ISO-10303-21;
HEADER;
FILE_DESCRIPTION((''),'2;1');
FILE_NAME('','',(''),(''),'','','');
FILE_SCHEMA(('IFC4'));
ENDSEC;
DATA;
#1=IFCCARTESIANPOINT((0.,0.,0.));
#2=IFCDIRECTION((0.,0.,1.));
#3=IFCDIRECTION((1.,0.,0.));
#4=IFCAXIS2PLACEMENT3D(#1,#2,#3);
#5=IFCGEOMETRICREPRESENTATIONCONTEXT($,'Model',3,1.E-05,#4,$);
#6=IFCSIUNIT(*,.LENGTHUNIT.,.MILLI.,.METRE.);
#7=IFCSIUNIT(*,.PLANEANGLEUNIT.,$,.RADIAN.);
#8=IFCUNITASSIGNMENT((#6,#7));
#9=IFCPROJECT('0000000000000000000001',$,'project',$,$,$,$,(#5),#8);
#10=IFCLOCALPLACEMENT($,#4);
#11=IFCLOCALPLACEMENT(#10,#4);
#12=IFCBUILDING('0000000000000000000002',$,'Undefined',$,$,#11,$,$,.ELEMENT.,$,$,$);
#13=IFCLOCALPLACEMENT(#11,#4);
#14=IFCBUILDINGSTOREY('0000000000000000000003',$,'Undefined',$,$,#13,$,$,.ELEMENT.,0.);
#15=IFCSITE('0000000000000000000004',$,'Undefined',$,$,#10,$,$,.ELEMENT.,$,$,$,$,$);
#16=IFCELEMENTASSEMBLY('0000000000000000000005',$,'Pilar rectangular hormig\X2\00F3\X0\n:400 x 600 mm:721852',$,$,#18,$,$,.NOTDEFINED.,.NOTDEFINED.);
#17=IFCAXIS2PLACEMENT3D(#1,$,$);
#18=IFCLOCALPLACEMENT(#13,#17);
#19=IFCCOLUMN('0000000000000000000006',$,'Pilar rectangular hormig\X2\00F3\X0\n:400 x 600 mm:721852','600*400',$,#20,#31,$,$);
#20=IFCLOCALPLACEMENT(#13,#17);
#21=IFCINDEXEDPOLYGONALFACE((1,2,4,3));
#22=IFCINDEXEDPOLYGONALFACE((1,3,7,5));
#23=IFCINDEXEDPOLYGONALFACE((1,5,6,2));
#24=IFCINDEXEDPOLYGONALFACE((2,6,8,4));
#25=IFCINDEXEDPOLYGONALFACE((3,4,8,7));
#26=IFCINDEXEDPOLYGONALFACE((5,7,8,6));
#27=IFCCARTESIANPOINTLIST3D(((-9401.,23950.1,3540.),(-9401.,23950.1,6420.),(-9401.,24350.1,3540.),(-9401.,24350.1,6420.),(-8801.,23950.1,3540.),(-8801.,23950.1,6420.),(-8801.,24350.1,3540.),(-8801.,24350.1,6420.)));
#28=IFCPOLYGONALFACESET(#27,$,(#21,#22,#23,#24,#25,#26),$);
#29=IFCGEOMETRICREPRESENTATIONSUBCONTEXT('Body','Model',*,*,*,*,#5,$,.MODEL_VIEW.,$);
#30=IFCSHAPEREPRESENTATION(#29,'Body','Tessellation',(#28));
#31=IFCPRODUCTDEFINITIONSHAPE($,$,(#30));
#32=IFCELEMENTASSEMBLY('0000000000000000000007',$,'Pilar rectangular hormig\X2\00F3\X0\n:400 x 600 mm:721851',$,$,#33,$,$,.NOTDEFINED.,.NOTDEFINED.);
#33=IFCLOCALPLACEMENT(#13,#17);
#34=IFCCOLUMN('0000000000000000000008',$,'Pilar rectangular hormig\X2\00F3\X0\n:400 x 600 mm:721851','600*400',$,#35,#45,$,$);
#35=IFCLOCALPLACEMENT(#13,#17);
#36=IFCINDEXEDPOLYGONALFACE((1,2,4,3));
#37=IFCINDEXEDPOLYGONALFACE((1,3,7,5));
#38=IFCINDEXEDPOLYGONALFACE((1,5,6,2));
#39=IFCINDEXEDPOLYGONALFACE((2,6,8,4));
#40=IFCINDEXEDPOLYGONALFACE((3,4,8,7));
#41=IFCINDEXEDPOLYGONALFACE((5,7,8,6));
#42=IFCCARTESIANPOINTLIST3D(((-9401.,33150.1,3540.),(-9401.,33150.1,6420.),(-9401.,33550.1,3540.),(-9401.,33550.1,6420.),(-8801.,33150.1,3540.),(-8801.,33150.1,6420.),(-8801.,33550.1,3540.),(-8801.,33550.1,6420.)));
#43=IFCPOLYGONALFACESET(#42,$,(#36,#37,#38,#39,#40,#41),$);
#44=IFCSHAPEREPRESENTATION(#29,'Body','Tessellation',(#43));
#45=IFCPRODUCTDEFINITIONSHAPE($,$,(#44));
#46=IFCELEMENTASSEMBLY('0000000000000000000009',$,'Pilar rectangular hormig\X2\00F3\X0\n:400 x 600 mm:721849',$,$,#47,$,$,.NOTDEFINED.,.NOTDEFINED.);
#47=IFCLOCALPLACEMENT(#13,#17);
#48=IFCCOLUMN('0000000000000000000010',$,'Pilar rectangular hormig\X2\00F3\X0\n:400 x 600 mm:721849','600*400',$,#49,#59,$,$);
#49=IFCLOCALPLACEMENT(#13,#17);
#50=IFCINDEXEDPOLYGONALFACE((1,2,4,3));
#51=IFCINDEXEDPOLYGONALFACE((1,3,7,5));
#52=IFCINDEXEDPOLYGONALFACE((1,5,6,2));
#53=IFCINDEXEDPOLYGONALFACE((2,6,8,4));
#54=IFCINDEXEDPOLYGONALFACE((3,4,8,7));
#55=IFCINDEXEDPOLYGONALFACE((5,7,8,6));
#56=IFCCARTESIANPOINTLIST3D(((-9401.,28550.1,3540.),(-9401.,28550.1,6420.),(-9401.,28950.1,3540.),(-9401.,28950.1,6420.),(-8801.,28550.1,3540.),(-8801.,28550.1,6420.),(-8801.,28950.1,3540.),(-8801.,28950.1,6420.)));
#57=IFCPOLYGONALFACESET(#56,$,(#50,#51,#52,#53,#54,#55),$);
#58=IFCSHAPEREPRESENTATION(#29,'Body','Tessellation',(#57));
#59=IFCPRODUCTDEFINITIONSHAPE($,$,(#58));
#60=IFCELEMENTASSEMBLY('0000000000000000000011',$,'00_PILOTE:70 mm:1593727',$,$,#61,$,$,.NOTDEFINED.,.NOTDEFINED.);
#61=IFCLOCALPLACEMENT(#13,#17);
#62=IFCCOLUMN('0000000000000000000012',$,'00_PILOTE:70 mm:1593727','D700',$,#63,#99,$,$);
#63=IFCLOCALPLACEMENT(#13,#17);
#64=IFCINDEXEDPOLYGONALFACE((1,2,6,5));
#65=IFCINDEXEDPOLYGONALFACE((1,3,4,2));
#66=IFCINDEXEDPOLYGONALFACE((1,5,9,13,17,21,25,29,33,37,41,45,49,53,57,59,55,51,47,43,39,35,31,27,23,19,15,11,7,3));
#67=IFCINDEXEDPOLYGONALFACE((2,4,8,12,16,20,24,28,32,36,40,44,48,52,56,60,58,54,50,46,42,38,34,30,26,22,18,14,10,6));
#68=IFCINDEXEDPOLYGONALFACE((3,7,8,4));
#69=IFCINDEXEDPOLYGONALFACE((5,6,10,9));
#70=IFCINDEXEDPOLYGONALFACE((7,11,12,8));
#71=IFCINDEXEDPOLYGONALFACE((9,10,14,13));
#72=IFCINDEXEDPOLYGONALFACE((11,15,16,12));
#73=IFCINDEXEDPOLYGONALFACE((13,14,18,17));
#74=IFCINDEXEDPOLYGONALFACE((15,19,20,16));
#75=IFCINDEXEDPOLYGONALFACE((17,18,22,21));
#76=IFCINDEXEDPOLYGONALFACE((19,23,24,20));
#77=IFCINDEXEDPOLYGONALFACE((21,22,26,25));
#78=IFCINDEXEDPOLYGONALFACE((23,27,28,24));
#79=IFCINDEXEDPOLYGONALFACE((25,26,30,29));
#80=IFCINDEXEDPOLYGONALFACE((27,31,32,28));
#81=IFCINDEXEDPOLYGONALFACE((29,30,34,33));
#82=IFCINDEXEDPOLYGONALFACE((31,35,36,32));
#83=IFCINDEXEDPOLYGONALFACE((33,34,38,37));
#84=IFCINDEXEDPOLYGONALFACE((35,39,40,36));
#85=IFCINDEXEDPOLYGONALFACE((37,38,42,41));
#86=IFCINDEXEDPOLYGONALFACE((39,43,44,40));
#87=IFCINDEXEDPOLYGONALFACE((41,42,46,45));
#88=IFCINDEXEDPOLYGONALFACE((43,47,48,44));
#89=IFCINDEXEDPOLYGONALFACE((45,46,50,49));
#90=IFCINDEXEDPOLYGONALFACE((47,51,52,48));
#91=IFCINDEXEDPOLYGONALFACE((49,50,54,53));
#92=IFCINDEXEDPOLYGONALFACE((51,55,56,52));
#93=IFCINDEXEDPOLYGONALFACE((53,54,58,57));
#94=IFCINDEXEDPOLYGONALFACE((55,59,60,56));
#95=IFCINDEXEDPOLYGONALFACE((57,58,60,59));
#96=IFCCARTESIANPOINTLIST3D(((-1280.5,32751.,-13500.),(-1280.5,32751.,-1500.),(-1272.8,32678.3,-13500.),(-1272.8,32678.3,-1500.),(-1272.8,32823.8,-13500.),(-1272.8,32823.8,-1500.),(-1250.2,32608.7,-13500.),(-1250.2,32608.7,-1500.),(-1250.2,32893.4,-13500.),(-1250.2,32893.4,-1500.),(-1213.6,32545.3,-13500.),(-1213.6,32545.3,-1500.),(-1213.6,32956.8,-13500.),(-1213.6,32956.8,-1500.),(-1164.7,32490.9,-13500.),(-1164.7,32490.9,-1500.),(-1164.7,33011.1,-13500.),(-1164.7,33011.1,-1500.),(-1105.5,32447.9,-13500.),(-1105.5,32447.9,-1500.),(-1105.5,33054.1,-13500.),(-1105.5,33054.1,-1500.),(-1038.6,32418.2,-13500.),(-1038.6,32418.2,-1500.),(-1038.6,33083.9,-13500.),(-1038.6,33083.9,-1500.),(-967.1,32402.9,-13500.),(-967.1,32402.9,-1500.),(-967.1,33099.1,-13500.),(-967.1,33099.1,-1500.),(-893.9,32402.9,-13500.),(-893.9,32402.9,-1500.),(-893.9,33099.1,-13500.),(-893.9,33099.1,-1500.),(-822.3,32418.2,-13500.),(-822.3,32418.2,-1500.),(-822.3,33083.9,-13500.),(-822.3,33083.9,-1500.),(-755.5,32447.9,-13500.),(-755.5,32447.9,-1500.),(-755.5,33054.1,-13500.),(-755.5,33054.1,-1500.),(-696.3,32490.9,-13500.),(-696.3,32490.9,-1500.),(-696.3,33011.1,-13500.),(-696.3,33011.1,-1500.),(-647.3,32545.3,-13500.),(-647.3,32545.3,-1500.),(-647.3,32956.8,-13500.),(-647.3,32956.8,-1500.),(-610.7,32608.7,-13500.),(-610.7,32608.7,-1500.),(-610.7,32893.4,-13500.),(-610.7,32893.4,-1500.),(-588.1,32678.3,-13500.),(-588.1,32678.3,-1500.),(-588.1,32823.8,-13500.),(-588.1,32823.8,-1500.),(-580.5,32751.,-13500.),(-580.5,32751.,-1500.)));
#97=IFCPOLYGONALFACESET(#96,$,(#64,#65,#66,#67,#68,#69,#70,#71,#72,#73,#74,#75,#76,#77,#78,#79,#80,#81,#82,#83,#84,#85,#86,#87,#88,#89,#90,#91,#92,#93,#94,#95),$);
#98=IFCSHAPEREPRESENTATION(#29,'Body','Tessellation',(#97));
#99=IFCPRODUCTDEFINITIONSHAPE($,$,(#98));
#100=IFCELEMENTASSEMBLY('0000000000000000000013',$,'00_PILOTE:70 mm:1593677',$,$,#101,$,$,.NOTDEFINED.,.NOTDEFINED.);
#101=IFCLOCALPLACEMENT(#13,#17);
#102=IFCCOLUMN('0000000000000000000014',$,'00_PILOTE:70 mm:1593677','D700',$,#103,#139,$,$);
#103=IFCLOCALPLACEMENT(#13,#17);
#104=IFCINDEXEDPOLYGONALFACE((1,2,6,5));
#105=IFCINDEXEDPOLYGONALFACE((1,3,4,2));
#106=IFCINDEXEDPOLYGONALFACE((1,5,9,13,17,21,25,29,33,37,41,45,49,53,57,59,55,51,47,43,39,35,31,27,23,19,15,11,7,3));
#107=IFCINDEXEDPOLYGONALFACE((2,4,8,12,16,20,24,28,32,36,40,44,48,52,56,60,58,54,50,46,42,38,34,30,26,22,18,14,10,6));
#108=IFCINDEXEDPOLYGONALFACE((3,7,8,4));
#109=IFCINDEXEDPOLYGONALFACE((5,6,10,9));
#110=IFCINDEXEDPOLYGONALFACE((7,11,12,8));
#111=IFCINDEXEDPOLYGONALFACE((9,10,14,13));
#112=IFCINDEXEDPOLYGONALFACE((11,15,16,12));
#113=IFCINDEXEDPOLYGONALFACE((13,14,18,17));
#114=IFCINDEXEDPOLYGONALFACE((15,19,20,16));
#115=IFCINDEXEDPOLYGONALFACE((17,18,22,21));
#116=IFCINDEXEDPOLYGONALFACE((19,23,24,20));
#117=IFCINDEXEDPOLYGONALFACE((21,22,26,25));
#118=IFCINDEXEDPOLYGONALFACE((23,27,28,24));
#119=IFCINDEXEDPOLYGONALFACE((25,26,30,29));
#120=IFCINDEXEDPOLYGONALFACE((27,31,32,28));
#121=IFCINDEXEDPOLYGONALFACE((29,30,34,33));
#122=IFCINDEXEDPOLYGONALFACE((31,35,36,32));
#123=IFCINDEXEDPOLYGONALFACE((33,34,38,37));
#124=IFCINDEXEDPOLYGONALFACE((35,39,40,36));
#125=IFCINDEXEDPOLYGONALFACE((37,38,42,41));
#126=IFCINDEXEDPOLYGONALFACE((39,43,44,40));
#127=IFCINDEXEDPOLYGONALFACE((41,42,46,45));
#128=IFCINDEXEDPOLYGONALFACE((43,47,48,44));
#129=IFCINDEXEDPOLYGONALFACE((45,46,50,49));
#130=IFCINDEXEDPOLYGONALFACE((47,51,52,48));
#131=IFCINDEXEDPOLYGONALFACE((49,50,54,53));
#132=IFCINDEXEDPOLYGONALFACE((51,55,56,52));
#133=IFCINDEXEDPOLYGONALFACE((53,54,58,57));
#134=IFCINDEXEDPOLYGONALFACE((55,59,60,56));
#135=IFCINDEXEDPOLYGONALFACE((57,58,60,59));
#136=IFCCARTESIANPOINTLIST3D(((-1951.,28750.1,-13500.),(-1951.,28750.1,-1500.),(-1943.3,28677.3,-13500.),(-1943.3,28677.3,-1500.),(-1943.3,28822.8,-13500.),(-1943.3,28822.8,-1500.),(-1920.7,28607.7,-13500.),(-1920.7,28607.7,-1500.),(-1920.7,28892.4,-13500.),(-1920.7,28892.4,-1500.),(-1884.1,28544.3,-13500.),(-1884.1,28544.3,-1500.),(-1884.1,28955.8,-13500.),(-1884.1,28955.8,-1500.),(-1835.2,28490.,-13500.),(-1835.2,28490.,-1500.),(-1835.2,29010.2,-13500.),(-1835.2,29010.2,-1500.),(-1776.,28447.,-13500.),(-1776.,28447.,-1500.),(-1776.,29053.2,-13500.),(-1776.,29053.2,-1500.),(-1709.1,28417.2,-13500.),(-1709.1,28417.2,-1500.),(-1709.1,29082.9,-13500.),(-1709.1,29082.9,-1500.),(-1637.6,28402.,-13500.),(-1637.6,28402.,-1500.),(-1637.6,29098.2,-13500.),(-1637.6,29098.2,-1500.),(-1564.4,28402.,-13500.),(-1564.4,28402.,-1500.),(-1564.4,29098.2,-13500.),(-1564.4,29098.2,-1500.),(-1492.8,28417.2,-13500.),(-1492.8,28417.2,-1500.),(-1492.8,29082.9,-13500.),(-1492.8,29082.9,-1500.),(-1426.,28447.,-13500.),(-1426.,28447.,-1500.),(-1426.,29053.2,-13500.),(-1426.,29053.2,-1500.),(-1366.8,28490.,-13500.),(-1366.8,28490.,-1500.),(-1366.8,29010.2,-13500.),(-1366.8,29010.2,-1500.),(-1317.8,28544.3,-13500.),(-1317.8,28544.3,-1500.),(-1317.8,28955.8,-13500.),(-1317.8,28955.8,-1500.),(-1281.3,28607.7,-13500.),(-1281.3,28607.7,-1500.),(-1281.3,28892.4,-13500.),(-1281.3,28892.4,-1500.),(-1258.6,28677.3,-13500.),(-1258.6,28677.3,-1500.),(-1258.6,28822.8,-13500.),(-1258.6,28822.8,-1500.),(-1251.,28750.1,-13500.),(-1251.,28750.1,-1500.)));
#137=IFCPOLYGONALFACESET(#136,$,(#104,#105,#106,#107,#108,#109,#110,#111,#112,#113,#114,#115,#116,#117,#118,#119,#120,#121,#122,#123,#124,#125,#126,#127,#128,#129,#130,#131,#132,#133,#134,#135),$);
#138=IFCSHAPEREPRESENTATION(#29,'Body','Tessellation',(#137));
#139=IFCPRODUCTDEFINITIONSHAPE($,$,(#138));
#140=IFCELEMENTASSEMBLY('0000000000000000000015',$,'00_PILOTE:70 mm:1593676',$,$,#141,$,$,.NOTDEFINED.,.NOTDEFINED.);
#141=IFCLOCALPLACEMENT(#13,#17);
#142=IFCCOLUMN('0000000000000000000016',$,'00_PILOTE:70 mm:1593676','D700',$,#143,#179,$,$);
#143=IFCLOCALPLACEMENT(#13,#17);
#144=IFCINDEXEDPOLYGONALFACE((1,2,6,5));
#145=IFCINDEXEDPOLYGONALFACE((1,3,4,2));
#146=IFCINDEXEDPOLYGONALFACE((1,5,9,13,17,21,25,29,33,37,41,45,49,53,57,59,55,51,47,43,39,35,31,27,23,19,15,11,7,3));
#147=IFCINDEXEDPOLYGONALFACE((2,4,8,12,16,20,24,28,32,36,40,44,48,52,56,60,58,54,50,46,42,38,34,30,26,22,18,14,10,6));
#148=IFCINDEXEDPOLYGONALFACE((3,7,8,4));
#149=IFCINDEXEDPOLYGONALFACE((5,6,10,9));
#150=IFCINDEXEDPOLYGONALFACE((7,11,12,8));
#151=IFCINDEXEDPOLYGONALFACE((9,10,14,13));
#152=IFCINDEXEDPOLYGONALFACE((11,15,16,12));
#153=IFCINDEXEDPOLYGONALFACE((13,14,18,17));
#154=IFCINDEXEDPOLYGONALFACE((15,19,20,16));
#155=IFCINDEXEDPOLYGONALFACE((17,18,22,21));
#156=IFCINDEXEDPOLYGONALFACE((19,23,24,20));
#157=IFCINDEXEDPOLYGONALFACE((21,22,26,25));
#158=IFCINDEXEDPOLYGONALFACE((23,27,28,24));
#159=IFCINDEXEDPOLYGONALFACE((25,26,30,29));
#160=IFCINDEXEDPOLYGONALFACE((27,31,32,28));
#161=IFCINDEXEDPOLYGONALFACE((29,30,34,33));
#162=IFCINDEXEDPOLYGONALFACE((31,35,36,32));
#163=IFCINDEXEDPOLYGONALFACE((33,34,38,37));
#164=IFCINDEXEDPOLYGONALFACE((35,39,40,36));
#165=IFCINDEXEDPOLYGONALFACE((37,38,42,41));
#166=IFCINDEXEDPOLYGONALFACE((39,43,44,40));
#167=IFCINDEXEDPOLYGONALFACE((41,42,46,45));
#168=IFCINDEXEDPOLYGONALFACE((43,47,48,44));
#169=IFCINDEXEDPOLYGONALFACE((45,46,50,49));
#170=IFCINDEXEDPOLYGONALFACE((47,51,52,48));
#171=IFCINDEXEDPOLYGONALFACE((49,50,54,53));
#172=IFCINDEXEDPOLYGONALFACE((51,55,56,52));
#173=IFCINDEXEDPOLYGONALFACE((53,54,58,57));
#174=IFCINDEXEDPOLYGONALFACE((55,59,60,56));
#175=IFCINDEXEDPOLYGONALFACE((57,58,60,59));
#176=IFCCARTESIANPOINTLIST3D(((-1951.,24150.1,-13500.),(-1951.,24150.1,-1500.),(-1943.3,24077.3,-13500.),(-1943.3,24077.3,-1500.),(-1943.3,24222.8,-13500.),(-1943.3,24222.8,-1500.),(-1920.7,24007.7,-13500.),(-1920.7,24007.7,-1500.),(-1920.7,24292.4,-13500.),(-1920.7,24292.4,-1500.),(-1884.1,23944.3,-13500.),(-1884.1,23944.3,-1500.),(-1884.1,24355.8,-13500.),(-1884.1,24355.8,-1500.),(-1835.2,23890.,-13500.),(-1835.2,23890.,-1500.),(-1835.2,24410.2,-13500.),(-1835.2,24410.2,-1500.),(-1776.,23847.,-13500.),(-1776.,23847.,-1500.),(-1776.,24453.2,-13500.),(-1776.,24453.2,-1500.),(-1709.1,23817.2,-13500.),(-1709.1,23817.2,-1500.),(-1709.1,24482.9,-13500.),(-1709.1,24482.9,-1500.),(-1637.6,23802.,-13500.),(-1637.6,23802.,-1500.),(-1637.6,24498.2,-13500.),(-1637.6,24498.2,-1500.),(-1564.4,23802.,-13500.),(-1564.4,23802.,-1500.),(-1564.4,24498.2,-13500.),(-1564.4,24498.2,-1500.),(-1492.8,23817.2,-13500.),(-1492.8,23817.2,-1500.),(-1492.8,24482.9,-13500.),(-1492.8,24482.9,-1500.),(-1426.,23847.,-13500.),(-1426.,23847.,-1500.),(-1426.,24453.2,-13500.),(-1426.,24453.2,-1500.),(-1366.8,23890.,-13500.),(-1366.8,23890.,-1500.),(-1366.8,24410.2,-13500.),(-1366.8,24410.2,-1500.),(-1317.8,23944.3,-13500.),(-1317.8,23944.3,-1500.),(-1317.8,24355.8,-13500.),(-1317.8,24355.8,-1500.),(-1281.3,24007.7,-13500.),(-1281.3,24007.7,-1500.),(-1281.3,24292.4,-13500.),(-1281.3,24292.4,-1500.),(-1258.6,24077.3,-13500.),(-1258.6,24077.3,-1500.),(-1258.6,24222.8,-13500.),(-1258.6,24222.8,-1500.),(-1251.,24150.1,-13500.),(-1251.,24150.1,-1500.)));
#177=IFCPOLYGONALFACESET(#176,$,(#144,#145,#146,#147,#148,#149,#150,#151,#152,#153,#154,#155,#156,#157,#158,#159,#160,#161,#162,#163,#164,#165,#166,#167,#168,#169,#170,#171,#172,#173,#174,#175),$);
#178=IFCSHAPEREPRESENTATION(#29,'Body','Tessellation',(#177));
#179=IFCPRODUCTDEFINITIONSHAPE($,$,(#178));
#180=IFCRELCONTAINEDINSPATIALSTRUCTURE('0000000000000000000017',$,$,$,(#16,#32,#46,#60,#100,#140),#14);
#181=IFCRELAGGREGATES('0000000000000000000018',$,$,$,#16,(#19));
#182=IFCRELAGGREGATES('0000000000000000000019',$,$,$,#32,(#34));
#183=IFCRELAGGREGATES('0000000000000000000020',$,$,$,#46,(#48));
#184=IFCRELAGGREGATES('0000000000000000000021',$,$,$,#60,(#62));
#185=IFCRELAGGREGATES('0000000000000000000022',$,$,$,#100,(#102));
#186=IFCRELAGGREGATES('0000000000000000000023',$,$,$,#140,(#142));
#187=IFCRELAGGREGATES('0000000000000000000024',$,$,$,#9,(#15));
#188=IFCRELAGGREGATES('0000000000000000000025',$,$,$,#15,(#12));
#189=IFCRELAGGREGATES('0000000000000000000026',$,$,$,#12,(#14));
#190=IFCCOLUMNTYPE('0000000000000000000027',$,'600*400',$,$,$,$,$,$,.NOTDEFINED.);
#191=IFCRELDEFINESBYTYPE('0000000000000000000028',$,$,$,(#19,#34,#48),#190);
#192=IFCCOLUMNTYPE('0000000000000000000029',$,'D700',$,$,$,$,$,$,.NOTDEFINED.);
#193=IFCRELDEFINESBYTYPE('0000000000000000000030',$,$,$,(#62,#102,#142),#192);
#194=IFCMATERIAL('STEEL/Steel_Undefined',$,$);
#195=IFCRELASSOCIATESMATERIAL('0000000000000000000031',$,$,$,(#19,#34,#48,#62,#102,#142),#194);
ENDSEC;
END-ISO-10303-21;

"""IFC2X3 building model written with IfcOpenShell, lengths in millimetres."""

from ifc_helpers import new_model, si_unit, frame, origin_with_axes, origin_2d_with_axis, place, context, subcontext, project, spatial, rectangle, circle, extrude, material, type_object, element, aggregate, save


model = new_model("IFC2X3")

# Units and contexts
model_context = context("Model", 3, precision=1e-05, world=origin_with_axes())
body_context = subcontext(model_context, "Body", "Model", "MODEL_VIEW")
ifc_project = project(units=[si_unit("LENGTHUNIT", "METRE", prefix="MILLI"), si_unit("PLANEANGLEUNIT", "RADIAN")], contexts=[model_context])

# Site, building, storey
site_placement = place(None, origin_with_axes())
site = spatial("IfcSite", under=ifc_project, at=site_placement, Name="Undefined", CompositionType="ELEMENT")
building_placement = place(site_placement, origin_with_axes())
building = spatial("IfcBuilding", under=site, at=building_placement, Name="Undefined", CompositionType="ELEMENT")
storey_placement = place(building_placement, origin_with_axes())
storey = spatial("IfcBuildingStorey", under=building, at=storey_placement, Name="Undefined", CompositionType="ELEMENT", Elevation=0.0)

# Element assemblies, columns
ifc_material_1 = material(Name="STEEL/Steel_Undefined")
assembly_1_placement = place(storey_placement, origin_with_axes())
assembly_1 = element("IfcElementAssembly", 1, at=assembly_1_placement, inside=storey, Name="Pilar rectangular hormigón:400 x 600 mm:721852", AssemblyPlace="NOTDEFINED", PredefinedType="NOTDEFINED")
column_type_1 = type_object("IfcColumnType", Name="600*400", PredefinedType="NOTDEFINED")
column_1_placement = place(assembly_1_placement, frame((-9101.0, 24150.1, 3540.0), z_axis=(0.0, 0.0, 1.0), x_axis=(1.0, 0.0, 0.0)))
column_1 = element("IfcColumn", 2, at=column_1_placement, type_object=column_type_1, material=ifc_material_1, Name="Pilar rectangular hormigón:400 x 600 mm:721852", Description="600*400", context=body_context, shape_type="SweptSolid", body=[
    extrude(rectangle(XDim=400.0, YDim=600.0, at=origin_2d_with_axis()), frame((0.0, 0.0, 2880.0), z_axis=(0.0, 0.0, -1.0), x_axis=(0.0, 1.0, 0.0)), (0.0, 0.0, 1.0), 2880.0),
])
aggregate(assembly_1, [column_1])
assembly_2_placement = place(storey_placement, origin_with_axes())
assembly_2 = element("IfcElementAssembly", 3, at=assembly_2_placement, inside=storey, Name="Pilar rectangular hormigón:400 x 600 mm:721851", AssemblyPlace="NOTDEFINED", PredefinedType="NOTDEFINED")
column_2_placement = place(assembly_2_placement, frame((-9101.0, 33350.1, 3540.0), z_axis=(0.0, 0.0, 1.0), x_axis=(1.0, 0.0, 0.0)))
column_2 = element("IfcColumn", 4, at=column_2_placement, type_object=column_type_1, material=ifc_material_1, Name="Pilar rectangular hormigón:400 x 600 mm:721851", Description="600*400", context=body_context, shape_type="SweptSolid", body=[
    extrude(rectangle(XDim=400.0, YDim=600.0, at=origin_2d_with_axis()), frame((0.0, 0.0, 2880.0), z_axis=(0.0, 0.0, -1.0), x_axis=(0.0, 1.0, 0.0)), (0.0, 0.0, 1.0), 2880.0),
])
aggregate(assembly_2, [column_2])
assembly_3_placement = place(storey_placement, origin_with_axes())
assembly_3 = element("IfcElementAssembly", 5, at=assembly_3_placement, inside=storey, Name="Pilar rectangular hormigón:400 x 600 mm:721849", AssemblyPlace="NOTDEFINED", PredefinedType="NOTDEFINED")
column_3_placement = place(assembly_3_placement, frame((-9101.0, 28750.1, 3540.0), z_axis=(0.0, 0.0, 1.0), x_axis=(-1.0, 0.0, 0.0)))
column_3 = element("IfcColumn", 6, at=column_3_placement, type_object=column_type_1, material=ifc_material_1, Name="Pilar rectangular hormigón:400 x 600 mm:721849", Description="600*400", context=body_context, shape_type="SweptSolid", body=[
    extrude(rectangle(XDim=400.0, YDim=600.0, at=origin_2d_with_axis()), frame((0.0, 0.0, 2880.0), z_axis=(0.0, 0.0, -1.0), x_axis=(0.0, 1.0, 0.0)), (0.0, 0.0, 1.0), 2880.0),
])
aggregate(assembly_3, [column_3])
assembly_4_placement = place(storey_placement, origin_with_axes())
assembly_4 = element("IfcElementAssembly", 7, at=assembly_4_placement, inside=storey, Name="00_PILOTE:70 mm:1593727", AssemblyPlace="NOTDEFINED", PredefinedType="NOTDEFINED")
column_type_2 = type_object("IfcColumnType", Name="D700", PredefinedType="NOTDEFINED")
column_4_placement = place(assembly_4_placement, frame((-930.5, 32751.0, -13500.0), z_axis=(0.0, 0.0, 1.0), x_axis=(0.0, 1.0, 0.0)))
column_4 = element("IfcColumn", 8, at=column_4_placement, type_object=column_type_2, material=ifc_material_1, Name="00_PILOTE:70 mm:1593727", Description="D700", context=body_context, shape_type="SweptSolid", body=[
    extrude(circle(Radius=350.0, at=origin_2d_with_axis()), frame((0.0, 0.0, 12000.0), z_axis=(0.0, 0.0, -1.0), x_axis=(0.0, 1.0, 0.0)), (0.0, 0.0, 1.0), 12000.0),
])
aggregate(assembly_4, [column_4])
assembly_5_placement = place(storey_placement, origin_with_axes())
assembly_5 = element("IfcElementAssembly", 9, at=assembly_5_placement, inside=storey, Name="00_PILOTE:70 mm:1593677", AssemblyPlace="NOTDEFINED", PredefinedType="NOTDEFINED")
column_5_placement = place(assembly_5_placement, frame((-1601.0, 28750.1, -13500.0), z_axis=(0.0, 0.0, 1.0), x_axis=(0.0, 1.0, 0.0)))
column_5 = element("IfcColumn", 10, at=column_5_placement, type_object=column_type_2, material=ifc_material_1, Name="00_PILOTE:70 mm:1593677", Description="D700", context=body_context, shape_type="SweptSolid", body=[
    extrude(circle(Radius=350.0, at=origin_2d_with_axis()), frame((0.0, 0.0, 12000.0), z_axis=(0.0, 0.0, -1.0), x_axis=(0.0, 1.0, 0.0)), (0.0, 0.0, 1.0), 12000.0),
])
aggregate(assembly_5, [column_5])
assembly_6_placement = place(storey_placement, origin_with_axes())
assembly_6 = element("IfcElementAssembly", 11, at=assembly_6_placement, inside=storey, Name="00_PILOTE:70 mm:1593676", AssemblyPlace="NOTDEFINED", PredefinedType="NOTDEFINED")
column_6_placement = place(assembly_6_placement, frame((-1601.0, 24150.1, -13500.0), z_axis=(0.0, 0.0, 1.0), x_axis=(0.0, 1.0, 0.0)))
column_6 = element("IfcColumn", 12, at=column_6_placement, type_object=column_type_2, material=ifc_material_1, Name="00_PILOTE:70 mm:1593676", Description="D700", context=body_context, shape_type="SweptSolid", body=[
    extrude(circle(Radius=350.0, at=origin_2d_with_axis()), frame((0.0, 0.0, 12000.0), z_axis=(0.0, 0.0, -1.0), x_axis=(0.0, 1.0, 0.0)), (0.0, 0.0, 1.0), 12000.0),
])
aggregate(assembly_6, [column_6])

save(model, "model.ifc")
